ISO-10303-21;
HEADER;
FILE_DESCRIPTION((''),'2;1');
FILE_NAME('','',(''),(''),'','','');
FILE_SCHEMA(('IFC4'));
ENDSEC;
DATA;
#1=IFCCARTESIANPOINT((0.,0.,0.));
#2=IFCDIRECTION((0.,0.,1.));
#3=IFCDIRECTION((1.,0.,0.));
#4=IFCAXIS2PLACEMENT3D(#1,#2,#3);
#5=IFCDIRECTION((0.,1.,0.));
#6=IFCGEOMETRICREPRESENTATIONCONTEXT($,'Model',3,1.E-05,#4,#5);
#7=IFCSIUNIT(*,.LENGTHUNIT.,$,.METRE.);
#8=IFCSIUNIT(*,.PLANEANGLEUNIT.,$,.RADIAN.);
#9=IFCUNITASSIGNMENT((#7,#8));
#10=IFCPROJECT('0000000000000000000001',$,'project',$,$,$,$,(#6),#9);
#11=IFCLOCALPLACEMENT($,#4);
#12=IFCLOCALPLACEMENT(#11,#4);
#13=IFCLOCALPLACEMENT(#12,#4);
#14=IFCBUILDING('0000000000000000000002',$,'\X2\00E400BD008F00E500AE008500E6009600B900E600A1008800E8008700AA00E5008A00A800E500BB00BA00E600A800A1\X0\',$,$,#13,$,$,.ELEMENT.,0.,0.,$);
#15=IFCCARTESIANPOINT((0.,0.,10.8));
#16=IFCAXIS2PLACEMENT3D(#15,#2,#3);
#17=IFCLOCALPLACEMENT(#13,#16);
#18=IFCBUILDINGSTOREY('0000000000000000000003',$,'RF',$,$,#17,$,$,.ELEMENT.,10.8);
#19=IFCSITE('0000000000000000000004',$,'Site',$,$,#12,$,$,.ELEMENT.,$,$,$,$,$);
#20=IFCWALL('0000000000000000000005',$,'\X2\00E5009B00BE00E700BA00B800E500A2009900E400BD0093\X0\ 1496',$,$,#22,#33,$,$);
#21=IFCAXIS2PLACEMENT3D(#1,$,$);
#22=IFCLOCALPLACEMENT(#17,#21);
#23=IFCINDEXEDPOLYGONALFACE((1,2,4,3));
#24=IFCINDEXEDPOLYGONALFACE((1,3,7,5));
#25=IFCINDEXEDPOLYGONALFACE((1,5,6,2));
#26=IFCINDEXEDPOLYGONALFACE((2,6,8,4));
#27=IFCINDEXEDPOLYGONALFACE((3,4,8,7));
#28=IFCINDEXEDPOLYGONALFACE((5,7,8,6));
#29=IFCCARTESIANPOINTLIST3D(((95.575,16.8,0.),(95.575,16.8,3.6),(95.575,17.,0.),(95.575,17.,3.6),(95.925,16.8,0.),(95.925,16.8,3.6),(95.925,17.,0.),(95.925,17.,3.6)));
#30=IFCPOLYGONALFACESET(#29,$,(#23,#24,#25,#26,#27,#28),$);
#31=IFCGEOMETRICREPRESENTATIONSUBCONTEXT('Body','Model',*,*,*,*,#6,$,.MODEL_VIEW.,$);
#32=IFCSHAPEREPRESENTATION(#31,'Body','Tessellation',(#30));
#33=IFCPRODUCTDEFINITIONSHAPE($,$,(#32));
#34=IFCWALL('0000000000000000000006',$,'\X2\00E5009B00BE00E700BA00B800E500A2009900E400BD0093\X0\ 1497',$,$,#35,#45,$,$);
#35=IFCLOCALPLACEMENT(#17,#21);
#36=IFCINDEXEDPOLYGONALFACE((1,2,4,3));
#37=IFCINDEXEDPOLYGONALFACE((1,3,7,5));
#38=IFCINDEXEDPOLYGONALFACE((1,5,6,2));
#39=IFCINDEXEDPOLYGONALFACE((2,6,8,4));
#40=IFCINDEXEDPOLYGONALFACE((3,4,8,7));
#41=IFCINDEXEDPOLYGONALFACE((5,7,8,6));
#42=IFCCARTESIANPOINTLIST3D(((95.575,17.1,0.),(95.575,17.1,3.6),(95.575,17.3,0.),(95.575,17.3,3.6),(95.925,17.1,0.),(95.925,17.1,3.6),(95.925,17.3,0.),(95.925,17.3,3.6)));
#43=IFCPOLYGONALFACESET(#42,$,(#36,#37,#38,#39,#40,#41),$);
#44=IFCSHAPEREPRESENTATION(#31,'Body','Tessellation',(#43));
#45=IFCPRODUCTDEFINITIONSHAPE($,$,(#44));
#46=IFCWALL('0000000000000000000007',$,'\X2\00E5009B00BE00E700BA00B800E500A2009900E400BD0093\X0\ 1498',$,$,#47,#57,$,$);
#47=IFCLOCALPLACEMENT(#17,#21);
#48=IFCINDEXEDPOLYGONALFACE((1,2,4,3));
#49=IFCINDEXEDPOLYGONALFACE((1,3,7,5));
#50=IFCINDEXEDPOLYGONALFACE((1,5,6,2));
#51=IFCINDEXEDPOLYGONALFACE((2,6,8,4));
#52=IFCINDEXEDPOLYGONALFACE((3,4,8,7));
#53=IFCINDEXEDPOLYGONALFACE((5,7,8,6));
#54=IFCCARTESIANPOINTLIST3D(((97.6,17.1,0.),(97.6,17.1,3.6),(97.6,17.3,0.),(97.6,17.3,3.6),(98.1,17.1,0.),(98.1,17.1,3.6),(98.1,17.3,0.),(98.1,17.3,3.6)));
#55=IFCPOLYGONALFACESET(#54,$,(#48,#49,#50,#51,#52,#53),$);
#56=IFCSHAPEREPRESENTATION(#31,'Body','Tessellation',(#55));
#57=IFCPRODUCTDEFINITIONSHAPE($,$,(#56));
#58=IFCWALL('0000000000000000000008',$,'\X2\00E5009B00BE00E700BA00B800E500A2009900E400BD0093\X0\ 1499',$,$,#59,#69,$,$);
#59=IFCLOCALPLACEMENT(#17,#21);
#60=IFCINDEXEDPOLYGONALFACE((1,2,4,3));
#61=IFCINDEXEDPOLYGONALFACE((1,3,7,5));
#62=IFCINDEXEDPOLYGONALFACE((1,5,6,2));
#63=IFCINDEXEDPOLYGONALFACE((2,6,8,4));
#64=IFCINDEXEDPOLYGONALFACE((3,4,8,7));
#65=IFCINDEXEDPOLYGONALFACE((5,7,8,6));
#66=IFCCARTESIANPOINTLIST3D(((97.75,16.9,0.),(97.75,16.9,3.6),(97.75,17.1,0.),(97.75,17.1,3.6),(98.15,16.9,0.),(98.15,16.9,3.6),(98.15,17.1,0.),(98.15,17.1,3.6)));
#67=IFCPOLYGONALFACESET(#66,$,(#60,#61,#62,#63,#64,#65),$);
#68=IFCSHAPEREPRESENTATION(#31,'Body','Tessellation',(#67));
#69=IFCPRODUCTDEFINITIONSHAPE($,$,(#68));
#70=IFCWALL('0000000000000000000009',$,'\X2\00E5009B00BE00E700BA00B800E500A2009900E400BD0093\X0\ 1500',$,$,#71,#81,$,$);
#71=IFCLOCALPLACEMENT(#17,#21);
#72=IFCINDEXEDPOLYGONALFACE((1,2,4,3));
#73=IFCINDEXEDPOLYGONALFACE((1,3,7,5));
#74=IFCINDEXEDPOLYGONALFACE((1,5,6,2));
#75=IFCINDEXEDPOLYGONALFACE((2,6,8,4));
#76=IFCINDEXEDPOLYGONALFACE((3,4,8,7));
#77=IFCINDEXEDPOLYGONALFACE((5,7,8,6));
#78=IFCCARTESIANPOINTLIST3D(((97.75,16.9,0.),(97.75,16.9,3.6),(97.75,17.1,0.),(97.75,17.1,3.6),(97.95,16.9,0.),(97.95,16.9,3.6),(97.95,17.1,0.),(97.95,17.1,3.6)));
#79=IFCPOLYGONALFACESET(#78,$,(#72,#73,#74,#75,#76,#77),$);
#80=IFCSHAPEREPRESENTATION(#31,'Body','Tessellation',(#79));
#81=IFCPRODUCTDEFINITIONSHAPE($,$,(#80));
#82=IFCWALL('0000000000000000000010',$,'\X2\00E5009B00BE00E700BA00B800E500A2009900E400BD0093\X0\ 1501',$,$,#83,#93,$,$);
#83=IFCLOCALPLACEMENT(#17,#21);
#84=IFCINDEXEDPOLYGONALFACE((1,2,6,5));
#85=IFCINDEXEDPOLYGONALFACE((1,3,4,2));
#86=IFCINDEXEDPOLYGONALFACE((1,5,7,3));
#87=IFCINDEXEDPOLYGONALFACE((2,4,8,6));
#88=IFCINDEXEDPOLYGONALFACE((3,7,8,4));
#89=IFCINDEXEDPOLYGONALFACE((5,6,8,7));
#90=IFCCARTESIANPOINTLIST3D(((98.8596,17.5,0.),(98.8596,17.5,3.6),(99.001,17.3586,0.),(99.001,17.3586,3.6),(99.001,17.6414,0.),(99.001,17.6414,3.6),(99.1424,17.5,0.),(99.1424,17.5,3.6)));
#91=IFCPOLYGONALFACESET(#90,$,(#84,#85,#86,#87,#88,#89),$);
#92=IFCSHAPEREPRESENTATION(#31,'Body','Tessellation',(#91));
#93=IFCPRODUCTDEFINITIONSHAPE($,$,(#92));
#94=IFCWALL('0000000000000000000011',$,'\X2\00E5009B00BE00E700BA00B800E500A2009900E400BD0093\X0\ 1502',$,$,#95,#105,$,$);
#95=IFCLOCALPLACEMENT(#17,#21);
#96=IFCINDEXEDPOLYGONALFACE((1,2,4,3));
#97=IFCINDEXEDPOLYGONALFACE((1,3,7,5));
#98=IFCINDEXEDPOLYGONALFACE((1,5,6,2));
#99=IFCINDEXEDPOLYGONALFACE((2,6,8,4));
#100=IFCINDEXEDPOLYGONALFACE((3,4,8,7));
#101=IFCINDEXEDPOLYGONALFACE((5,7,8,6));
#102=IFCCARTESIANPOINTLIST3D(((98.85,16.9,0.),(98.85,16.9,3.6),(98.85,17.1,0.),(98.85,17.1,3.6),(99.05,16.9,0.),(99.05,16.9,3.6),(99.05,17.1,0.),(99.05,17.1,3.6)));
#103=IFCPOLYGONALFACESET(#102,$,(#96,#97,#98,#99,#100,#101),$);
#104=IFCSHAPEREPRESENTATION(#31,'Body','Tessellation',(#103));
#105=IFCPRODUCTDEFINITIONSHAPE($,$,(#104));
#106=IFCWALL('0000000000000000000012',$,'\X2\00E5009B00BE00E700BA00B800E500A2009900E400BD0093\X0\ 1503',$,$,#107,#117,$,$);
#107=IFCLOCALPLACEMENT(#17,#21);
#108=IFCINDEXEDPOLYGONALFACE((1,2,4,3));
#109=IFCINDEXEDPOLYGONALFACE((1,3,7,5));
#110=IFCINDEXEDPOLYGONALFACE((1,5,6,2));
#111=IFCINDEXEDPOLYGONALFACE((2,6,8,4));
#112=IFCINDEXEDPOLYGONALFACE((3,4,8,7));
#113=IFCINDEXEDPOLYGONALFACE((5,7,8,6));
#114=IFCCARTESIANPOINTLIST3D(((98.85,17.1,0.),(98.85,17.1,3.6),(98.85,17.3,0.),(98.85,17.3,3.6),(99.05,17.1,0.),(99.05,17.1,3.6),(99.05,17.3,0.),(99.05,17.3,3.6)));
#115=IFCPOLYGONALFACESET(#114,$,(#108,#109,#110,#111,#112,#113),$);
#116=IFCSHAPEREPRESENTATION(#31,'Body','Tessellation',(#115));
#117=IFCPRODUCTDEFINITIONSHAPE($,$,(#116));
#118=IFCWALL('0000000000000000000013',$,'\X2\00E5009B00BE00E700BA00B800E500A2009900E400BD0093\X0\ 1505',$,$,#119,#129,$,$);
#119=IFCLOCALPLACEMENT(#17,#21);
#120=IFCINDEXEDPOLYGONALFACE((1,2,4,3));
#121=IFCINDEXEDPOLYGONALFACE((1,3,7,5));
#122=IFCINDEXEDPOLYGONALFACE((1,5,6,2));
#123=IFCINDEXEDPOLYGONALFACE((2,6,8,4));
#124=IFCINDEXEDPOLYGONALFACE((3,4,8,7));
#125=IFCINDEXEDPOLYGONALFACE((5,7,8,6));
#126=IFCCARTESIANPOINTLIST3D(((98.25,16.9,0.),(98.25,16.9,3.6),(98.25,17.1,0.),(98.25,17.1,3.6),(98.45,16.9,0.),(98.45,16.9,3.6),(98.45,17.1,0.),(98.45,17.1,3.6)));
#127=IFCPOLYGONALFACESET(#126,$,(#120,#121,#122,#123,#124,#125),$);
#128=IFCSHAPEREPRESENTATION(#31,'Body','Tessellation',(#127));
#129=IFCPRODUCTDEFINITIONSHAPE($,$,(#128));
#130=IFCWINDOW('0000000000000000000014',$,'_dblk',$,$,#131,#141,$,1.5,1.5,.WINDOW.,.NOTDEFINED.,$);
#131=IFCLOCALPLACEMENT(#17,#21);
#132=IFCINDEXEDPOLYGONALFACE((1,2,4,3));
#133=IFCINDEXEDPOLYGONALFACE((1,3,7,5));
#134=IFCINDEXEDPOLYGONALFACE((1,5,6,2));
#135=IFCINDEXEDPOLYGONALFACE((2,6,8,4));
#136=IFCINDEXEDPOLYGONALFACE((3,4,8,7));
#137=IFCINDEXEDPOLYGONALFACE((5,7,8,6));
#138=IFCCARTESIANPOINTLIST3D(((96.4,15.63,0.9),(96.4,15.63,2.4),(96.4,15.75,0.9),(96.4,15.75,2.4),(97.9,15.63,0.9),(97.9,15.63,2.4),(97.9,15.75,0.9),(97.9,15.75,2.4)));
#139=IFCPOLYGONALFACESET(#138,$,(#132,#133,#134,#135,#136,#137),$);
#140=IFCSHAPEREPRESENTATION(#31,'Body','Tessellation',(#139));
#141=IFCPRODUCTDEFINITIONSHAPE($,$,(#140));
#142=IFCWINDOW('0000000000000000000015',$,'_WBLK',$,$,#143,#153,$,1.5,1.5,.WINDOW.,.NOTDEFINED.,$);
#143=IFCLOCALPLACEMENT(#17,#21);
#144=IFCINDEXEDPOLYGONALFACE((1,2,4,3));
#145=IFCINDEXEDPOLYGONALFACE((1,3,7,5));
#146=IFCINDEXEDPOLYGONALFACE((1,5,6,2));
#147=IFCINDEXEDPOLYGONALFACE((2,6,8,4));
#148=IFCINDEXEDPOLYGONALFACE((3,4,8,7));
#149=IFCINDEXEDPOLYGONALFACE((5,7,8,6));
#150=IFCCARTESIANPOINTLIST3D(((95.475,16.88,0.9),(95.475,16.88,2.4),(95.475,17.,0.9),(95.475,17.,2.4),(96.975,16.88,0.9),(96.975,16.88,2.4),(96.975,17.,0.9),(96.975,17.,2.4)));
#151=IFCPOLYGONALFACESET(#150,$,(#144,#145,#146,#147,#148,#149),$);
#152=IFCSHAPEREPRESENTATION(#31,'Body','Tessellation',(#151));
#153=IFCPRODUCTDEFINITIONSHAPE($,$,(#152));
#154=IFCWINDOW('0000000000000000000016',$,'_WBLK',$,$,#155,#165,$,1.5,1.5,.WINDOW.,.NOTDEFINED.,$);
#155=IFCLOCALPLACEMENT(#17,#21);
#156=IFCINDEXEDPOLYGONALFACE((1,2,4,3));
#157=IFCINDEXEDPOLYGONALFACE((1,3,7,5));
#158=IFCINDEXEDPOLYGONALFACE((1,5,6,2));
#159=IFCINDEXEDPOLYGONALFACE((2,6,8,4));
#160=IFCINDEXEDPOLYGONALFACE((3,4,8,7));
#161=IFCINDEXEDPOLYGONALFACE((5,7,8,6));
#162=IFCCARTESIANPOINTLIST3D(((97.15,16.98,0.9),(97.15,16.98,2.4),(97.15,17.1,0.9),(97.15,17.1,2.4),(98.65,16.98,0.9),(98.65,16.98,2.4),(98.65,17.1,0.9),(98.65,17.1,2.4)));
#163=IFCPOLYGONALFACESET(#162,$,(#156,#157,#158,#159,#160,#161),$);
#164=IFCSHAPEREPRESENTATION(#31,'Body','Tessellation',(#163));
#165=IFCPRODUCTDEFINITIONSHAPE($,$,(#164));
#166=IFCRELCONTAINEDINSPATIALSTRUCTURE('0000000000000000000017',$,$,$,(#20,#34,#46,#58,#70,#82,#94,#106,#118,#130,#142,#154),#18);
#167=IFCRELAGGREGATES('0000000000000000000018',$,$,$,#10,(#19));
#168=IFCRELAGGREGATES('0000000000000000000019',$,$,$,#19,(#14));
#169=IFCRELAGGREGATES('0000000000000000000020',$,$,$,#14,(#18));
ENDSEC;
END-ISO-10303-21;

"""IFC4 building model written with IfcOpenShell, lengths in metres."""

from ifc_helpers import new_model, si_unit, direction, frame, frame_2d, origin_with_axes, place, context, subcontext, project, spatial, rectangle, extrude, element, save


model = new_model("IFC4")

# Units and contexts
model_context = context("Model", 3, precision=1e-05, world=origin_with_axes(), true_north=direction((0.0, 1.0, 0.0)))
body_context = subcontext(model_context, "Body", "Model", "MODEL_VIEW")
ifc_project = project(units=[si_unit("LENGTHUNIT", "METRE"), si_unit("PLANEANGLEUNIT", "RADIAN")], contexts=[model_context])

# Site, building, storey
placement = place(None, origin_with_axes())
site_placement = place(placement, origin_with_axes())
site = spatial("IfcSite", under=ifc_project, at=site_placement, Name="Site", CompositionType="ELEMENT")
building_placement = place(site_placement, origin_with_axes())
building = spatial("IfcBuilding", under=site, at=building_placement, Name="ä½\u008få®\u0085æ\u0096¹æ¡\u0088è\u0087ªå\u008a¨å»ºæ¨¡", CompositionType="ELEMENT", ElevationOfRefHeight=0.0, ElevationOfTerrain=0.0)
storey_placement = place(building_placement, frame((0.0, 0.0, 10.8), z_axis=(0.0, 0.0, 1.0), x_axis=(1.0, 0.0, 0.0)))
storey = spatial("IfcBuildingStorey", under=building, at=storey_placement, Name="RF", CompositionType="ELEMENT", Elevation=10.8)

# Walls
for number, where, z_axis, x_axis, name in (
    (1, (95.75, 16.9, 0.0), (0.0, 0.0, 1.0), (1.0, 0.0, 0.0), "å\u009b¾çº¸å¢\u0099ä½\u0093 1496"),
    (2, (95.75, 17.2, 0.0), (0.0, 0.0, 1.0), (1.0, 0.0, 0.0), "å\u009b¾çº¸å¢\u0099ä½\u0093 1497"),
):
    element("IfcWall", number, at=place(storey_placement, frame(where, z_axis=z_axis, x_axis=x_axis)), inside=storey, Name=name, context=body_context, shape_type="SweptSolid", body=[
        extrude(rectangle(XDim=0.35, YDim=0.2, at=frame_2d((0.0, 0.0), x_axis=(1.0, 0.0, 0.0))), frame((0.0, 0.0, 0.0), z_axis=(0.0, 0.0, 1.0)), (0.0, 0.0, 1.0), 3.6),
    ])
wall_1_placement = place(storey_placement, frame((97.85, 17.2, 0.0), z_axis=(0.0, 0.0, 1.0), x_axis=(1.0, 0.0, 0.0)))
element("IfcWall", 3, at=wall_1_placement, inside=storey, Name="å\u009b¾çº¸å¢\u0099ä½\u0093 1498", context=body_context, shape_type="SweptSolid", body=[
    extrude(rectangle(XDim=0.5, YDim=0.2, at=frame_2d((0.0, 0.0), x_axis=(1.0, 0.0, 0.0))), frame((0.0, 0.0, 0.0), z_axis=(0.0, 0.0, 1.0)), (0.0, 0.0, 1.0), 3.6),
])
wall_2_placement = place(storey_placement, frame((97.95, 17.0, 0.0), z_axis=(0.0, 0.0, 1.0), x_axis=(1.0, 0.0, 0.0)))
element("IfcWall", 4, at=wall_2_placement, inside=storey, Name="å\u009b¾çº¸å¢\u0099ä½\u0093 1499", context=body_context, shape_type="SweptSolid", body=[
    extrude(rectangle(XDim=0.4, YDim=0.2, at=frame_2d((0.0, 0.0), x_axis=(1.0, 0.0, 0.0))), frame((0.0, 0.0, 0.0), z_axis=(0.0, 0.0, 1.0)), (0.0, 0.0, 1.0), 3.6),
])
for number, where, z_axis, x_axis, name in (
    (5, (97.85, 17.0, 0.0), (0.0, 0.0, 1.0), (0.0, 1.0, 0.0), "å\u009b¾çº¸å¢\u0099ä½\u0093 1500"),
    (6, (99.001, 17.5, 0.0), (0.0, 0.0, 1.0), (-0.707107, -0.707107, 0.0), "å\u009b¾çº¸å¢\u0099ä½\u0093 1501"),
    (7, (98.95, 17.0, 0.0), (0.0, 0.0, 1.0), (1.0, 0.0, 0.0), "å\u009b¾çº¸å¢\u0099ä½\u0093 1502"),
    (8, (98.95, 17.2, 0.0), (0.0, 0.0, 1.0), (1.0, 0.0, 0.0), "å\u009b¾çº¸å¢\u0099ä½\u0093 1503"),
    (9, (98.35, 17.0, 0.0), (0.0, 0.0, 1.0), (0.0, 1.0, 0.0), "å\u009b¾çº¸å¢\u0099ä½\u0093 1505"),
):
    element("IfcWall", number, at=place(storey_placement, frame(where, z_axis=z_axis, x_axis=x_axis)), inside=storey, Name=name, context=body_context, shape_type="SweptSolid", body=[
        extrude(rectangle(XDim=0.2, YDim=0.2, at=frame_2d((0.0, 0.0), x_axis=(1.0, 0.0, 0.0))), frame((0.0, 0.0, 0.0), z_axis=(0.0, 0.0, 1.0)), (0.0, 0.0, 1.0), 3.6),
    ])

# Windows
for number, where, z_axis, x_axis, name in (
    (10, (97.15, 15.69, 0.9), (0.0, 0.0, 1.0), (1.0, 0.0, 0.0), "_dblk"),
    (11, (96.225, 16.94, 0.9), (0.0, 0.0, 1.0), (1.0, 0.0, 0.0), "_WBLK"),
    (12, (97.9, 17.04, 0.9), (0.0, 0.0, 1.0), (1.0, 0.0, 0.0), "_WBLK"),
):
    element("IfcWindow", number, at=place(storey_placement, frame(where, z_axis=z_axis, x_axis=x_axis)), inside=storey, Name=name, OverallHeight=1.5, OverallWidth=1.5, PartitioningType="NOTDEFINED", PredefinedType="WINDOW", context=body_context, shape_type="SweptSolid", body=[
        extrude(rectangle(XDim=1.5, YDim=0.12, at=frame_2d((0.0, 0.0), x_axis=(1.0, 0.0, 0.0))), frame((0.0, 0.0, 0.0), z_axis=(0.0, 0.0, 1.0)), (0.0, 0.0, 1.0), 1.5),
    ])

save(model, "model.ifc")
